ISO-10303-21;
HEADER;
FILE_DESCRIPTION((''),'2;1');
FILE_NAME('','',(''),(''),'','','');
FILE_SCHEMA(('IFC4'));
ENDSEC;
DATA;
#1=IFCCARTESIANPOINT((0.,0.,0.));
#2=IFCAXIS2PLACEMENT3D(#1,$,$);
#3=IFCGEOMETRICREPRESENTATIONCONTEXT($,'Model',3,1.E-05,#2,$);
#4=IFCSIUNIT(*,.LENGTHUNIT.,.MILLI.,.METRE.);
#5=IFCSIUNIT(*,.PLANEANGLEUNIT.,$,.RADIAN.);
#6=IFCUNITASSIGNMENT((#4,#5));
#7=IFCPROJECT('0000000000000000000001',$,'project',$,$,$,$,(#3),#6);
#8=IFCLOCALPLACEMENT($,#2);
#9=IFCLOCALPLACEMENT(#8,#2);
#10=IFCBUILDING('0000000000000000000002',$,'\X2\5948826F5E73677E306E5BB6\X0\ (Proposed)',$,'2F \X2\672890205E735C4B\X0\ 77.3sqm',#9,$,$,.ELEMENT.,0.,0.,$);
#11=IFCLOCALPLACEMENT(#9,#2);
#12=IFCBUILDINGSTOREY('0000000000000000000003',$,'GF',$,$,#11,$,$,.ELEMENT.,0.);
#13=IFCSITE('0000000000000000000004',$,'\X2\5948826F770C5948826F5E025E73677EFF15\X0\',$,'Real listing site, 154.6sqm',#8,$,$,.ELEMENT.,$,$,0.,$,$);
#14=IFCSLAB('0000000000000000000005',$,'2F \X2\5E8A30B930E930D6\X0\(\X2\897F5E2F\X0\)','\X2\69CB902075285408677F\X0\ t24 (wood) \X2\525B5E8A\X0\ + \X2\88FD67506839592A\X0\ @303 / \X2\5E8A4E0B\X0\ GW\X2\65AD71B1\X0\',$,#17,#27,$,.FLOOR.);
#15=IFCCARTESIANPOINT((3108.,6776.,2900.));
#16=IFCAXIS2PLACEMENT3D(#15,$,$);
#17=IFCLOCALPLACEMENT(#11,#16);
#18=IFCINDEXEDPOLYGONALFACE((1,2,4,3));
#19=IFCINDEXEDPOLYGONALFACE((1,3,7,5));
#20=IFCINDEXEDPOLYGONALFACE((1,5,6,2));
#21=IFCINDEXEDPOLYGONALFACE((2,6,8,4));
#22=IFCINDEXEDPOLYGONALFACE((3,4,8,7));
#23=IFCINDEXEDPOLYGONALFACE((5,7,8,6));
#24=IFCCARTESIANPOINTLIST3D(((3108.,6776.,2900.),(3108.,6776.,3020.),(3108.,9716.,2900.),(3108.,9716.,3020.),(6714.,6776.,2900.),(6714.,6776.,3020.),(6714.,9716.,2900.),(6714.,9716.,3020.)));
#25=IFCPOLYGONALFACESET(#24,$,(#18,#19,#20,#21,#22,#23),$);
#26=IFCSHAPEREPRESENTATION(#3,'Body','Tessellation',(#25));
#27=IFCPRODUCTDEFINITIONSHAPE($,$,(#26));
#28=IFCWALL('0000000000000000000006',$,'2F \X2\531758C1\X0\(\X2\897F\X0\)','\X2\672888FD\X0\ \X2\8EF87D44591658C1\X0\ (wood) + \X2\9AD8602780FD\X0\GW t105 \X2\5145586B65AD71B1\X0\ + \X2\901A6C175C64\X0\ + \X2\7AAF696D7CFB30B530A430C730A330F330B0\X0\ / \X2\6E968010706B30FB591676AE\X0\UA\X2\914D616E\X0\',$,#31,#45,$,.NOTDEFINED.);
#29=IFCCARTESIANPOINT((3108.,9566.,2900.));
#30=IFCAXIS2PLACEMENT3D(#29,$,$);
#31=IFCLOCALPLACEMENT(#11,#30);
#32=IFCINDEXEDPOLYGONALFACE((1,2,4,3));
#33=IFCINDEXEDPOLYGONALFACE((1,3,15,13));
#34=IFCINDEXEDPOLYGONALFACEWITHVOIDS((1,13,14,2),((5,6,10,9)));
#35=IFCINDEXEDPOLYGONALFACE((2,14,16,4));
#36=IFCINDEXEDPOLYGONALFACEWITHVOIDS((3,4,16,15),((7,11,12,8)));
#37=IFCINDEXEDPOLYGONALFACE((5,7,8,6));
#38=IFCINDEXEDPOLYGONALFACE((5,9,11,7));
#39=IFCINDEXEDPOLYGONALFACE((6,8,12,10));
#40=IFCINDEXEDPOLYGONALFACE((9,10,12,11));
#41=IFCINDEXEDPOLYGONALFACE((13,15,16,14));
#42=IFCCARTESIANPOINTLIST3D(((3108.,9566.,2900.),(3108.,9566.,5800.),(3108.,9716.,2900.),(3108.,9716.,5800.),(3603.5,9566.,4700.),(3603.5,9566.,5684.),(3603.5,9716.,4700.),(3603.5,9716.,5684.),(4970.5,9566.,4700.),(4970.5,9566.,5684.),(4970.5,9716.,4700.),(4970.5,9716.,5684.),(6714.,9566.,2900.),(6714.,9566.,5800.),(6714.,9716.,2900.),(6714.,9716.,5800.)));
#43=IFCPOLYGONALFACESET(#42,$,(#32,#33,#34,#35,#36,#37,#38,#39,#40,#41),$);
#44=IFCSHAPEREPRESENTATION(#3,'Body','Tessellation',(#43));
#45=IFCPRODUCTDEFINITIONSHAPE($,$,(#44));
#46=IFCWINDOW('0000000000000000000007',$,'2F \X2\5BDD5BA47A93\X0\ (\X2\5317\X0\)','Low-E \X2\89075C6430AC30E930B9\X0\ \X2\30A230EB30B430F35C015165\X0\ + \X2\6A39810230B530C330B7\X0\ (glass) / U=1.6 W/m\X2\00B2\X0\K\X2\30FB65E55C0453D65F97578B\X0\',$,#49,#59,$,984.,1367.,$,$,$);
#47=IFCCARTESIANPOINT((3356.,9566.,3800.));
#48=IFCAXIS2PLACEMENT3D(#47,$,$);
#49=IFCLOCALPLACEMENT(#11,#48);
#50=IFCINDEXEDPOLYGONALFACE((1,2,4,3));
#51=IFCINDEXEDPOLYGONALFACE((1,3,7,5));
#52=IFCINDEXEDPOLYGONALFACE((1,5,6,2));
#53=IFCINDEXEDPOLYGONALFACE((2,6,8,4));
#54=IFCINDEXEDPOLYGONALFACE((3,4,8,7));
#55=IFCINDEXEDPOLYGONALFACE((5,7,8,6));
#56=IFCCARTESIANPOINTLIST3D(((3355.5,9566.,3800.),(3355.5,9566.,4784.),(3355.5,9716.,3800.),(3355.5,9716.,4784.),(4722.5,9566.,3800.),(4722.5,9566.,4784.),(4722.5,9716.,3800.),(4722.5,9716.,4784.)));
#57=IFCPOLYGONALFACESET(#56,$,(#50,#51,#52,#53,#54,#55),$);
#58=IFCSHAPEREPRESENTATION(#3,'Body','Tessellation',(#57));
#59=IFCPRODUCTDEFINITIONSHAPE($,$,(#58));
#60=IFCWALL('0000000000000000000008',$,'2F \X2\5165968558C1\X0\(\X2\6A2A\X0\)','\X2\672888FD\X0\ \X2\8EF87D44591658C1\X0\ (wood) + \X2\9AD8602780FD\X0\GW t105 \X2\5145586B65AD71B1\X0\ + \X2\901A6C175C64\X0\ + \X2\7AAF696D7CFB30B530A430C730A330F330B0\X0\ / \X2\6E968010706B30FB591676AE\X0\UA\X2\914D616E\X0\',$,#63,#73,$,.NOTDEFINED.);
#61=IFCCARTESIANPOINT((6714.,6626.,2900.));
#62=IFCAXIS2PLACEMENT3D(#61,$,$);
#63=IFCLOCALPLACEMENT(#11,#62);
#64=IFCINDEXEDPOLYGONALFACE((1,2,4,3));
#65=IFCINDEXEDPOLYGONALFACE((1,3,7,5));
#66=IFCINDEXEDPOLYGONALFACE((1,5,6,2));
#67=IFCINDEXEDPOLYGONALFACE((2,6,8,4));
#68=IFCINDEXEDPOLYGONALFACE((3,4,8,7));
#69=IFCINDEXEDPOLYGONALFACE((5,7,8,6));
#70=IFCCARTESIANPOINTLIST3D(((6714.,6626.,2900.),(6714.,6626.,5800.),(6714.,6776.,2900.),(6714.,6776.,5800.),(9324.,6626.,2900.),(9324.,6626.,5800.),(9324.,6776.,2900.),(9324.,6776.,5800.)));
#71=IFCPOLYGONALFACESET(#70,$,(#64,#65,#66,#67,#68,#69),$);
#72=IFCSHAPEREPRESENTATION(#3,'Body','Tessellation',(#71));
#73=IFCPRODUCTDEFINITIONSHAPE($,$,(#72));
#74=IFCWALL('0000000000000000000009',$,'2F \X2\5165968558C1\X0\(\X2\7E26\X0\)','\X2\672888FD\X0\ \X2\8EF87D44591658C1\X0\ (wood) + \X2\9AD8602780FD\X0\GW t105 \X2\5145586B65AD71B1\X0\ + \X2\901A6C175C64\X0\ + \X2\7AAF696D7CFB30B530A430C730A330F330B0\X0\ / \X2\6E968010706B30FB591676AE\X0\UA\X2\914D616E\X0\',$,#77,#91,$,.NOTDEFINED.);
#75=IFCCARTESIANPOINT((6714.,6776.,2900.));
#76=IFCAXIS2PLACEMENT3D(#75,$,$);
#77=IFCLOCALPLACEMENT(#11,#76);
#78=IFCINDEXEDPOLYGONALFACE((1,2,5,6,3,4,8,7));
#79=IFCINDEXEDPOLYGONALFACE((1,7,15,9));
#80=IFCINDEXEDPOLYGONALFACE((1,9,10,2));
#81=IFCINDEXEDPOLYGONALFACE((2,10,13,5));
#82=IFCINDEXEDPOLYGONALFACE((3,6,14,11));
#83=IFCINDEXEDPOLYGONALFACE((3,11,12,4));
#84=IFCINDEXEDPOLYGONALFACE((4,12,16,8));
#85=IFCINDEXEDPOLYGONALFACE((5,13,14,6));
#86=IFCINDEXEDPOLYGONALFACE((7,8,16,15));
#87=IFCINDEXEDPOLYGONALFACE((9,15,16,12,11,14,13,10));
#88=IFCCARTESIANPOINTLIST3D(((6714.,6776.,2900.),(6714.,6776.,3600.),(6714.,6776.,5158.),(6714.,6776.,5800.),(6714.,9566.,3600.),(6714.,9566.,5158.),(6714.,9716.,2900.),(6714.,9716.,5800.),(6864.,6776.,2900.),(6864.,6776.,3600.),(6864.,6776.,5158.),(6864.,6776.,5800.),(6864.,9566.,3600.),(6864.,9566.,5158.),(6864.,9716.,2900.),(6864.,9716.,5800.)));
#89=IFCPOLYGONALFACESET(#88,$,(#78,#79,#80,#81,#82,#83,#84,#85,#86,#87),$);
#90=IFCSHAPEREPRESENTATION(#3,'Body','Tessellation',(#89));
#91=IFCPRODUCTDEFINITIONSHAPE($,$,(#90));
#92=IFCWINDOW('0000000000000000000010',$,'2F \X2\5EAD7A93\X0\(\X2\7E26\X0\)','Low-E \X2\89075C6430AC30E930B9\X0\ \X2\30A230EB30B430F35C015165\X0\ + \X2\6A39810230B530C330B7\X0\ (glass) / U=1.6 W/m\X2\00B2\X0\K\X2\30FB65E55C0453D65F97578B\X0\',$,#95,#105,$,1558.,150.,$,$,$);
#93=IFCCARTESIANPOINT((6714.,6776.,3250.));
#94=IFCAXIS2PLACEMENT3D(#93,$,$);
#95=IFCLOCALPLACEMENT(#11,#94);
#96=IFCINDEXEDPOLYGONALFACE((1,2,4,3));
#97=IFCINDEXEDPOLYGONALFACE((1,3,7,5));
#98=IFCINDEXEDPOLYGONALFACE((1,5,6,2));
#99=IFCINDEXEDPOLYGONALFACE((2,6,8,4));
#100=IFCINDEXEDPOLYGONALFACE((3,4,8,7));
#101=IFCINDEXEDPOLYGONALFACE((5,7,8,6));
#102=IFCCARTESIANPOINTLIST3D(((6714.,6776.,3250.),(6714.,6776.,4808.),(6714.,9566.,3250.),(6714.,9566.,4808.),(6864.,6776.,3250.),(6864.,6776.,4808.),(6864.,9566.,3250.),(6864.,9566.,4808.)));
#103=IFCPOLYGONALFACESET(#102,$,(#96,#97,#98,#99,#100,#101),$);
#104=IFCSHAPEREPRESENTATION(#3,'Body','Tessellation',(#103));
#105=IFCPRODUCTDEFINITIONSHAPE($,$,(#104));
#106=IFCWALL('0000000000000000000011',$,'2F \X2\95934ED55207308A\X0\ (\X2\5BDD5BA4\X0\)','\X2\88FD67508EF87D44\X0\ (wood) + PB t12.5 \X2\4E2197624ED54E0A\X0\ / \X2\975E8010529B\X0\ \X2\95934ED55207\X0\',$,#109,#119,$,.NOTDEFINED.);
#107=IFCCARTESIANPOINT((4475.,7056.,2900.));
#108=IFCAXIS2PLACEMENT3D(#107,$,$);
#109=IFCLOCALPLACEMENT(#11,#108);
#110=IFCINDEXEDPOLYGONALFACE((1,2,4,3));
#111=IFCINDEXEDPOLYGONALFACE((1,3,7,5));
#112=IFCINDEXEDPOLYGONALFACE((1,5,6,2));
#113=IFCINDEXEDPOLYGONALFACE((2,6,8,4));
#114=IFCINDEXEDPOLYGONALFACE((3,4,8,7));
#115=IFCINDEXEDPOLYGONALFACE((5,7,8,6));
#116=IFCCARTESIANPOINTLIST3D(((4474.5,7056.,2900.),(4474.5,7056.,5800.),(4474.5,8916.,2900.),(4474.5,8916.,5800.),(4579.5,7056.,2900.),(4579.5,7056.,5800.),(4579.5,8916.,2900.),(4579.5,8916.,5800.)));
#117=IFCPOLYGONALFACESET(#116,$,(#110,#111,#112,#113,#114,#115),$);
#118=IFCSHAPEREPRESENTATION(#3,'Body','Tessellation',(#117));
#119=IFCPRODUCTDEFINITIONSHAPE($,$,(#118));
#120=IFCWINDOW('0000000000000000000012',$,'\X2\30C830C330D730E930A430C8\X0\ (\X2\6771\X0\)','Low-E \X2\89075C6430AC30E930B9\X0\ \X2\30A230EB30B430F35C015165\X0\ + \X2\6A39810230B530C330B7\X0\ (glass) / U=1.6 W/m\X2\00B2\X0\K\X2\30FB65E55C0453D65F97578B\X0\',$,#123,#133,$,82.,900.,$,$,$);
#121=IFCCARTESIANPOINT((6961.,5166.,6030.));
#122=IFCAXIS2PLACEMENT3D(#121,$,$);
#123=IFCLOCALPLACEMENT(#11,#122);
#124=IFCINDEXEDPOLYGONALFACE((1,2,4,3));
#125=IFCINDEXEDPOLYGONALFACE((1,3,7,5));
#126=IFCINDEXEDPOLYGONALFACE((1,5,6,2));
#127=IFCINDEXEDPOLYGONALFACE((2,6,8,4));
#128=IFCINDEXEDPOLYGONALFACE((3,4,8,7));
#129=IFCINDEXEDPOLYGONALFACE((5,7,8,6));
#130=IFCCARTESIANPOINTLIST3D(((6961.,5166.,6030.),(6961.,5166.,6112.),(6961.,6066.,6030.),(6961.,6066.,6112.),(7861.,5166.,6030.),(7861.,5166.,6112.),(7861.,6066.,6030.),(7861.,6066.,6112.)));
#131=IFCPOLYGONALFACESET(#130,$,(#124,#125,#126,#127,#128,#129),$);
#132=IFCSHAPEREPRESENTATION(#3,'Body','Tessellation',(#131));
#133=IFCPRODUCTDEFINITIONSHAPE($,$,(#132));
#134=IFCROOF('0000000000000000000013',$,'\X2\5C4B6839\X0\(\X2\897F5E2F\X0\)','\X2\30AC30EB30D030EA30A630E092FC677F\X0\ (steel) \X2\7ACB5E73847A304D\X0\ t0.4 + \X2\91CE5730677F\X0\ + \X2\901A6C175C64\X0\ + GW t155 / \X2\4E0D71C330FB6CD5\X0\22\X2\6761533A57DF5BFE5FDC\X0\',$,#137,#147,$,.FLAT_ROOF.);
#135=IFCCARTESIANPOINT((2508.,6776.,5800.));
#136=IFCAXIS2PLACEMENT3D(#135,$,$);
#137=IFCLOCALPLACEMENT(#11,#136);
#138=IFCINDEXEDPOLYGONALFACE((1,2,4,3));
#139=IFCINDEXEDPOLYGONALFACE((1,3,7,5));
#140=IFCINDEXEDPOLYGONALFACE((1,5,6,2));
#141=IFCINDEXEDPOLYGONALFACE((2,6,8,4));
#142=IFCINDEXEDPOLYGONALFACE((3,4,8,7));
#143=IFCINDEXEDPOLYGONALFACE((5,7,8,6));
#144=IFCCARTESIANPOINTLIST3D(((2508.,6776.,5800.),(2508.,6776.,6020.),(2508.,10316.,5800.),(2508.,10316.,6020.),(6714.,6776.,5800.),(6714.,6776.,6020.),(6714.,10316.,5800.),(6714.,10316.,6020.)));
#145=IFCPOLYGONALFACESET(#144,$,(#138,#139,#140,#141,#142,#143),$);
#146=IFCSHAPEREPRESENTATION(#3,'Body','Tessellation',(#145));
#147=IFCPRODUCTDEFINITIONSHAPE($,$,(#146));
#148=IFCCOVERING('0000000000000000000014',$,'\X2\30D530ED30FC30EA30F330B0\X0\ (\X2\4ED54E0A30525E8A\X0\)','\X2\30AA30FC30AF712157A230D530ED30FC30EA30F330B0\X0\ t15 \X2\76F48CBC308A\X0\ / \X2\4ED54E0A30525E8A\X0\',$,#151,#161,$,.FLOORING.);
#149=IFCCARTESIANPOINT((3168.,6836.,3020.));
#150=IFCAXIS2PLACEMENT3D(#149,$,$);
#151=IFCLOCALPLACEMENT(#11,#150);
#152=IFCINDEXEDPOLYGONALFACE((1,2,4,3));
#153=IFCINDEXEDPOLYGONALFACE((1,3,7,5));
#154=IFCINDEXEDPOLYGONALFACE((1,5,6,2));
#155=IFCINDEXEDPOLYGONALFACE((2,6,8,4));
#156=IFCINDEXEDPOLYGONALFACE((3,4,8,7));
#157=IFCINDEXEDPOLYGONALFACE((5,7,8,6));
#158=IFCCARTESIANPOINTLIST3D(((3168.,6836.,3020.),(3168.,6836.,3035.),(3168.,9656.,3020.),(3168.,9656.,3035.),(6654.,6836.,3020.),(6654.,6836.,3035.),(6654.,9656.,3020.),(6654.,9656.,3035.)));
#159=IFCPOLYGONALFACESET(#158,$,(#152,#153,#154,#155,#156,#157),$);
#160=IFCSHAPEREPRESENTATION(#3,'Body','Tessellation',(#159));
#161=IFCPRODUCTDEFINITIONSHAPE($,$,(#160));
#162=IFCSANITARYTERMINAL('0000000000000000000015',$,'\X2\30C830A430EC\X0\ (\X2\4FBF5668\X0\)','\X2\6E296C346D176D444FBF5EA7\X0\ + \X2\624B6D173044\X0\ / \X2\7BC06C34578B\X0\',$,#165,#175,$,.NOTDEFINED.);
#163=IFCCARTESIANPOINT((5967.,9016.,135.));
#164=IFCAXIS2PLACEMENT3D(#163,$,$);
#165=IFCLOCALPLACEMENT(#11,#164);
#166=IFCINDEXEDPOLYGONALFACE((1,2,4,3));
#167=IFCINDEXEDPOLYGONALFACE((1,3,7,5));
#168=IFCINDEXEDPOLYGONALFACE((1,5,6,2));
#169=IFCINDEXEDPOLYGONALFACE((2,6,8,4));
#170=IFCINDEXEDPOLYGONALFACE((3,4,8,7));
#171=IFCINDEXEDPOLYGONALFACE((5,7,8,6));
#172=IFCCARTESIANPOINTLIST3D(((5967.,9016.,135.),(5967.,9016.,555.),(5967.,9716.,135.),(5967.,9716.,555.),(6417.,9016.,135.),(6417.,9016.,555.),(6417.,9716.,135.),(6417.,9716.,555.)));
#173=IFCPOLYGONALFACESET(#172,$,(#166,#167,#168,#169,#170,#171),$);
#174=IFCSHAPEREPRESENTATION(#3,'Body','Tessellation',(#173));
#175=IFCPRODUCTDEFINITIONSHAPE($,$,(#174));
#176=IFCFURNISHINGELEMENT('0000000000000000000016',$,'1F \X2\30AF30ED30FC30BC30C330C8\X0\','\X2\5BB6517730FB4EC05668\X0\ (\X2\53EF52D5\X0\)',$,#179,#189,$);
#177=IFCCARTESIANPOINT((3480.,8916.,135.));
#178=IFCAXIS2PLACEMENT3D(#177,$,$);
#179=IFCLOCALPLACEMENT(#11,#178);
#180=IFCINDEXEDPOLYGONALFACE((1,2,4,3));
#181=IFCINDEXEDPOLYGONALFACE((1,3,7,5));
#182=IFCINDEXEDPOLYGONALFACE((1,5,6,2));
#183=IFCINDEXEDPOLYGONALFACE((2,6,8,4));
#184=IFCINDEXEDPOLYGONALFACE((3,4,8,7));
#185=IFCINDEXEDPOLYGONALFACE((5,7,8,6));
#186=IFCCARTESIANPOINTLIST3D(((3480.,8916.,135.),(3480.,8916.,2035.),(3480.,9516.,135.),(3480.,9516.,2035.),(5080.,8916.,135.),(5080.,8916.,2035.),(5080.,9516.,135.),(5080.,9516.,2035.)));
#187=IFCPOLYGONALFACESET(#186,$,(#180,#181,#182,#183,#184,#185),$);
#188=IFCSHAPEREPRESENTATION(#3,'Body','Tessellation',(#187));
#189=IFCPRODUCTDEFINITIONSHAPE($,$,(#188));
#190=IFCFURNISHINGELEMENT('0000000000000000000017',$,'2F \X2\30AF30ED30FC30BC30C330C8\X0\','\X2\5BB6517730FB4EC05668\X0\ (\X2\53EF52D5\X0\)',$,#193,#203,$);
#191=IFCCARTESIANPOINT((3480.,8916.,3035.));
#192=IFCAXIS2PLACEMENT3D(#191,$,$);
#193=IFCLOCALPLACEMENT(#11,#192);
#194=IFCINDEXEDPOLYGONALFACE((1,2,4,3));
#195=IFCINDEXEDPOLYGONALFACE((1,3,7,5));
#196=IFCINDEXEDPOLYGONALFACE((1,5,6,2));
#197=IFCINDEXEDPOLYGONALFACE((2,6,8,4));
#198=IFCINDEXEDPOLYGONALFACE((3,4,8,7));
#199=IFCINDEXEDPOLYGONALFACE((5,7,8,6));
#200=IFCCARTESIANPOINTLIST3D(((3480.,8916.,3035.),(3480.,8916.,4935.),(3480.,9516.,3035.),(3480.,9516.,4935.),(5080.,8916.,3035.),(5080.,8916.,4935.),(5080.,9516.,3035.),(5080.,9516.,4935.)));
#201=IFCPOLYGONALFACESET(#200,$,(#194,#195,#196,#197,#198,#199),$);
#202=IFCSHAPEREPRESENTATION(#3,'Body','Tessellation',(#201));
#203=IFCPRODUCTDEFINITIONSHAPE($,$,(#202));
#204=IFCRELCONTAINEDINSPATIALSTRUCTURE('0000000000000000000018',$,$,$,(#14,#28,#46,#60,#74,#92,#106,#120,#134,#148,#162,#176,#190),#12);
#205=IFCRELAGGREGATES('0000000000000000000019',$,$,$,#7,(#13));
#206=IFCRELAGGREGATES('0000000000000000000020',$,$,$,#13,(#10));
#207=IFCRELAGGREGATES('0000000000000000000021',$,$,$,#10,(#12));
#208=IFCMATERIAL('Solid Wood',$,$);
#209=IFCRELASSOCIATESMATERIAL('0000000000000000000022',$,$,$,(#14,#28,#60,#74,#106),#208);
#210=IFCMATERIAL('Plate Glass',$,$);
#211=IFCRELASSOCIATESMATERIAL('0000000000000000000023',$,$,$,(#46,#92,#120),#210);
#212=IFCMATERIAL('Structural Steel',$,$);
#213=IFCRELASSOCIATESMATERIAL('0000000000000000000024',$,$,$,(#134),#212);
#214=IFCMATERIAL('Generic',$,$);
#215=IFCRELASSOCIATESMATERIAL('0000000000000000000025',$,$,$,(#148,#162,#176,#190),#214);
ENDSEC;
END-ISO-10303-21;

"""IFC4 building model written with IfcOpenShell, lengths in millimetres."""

from ifc_helpers import new_model, si_unit, frame, frame_2d, origin, place, context, project, spatial, rectangle, extrude, material, element, fill, save


model = new_model("IFC4")

# Units and contexts
model_context = context("Model", 3, precision=1e-05, world=origin())
ifc_project = project(units=[si_unit("LENGTHUNIT", "METRE", prefix="MILLI"), si_unit("PLANEANGLEUNIT", "RADIAN")], contexts=[model_context])

# Site, building, storey
site_placement = place(None, origin())
site = spatial("IfcSite", under=ifc_project, at=site_placement, Name="奈良県奈良市平松５", ObjectType="Real listing site, 154.6sqm", CompositionType="ELEMENT", RefElevation=0.0)
building_placement = place(site_placement, origin())
building = spatial("IfcBuilding", under=site, at=building_placement, Name="奈良平松の家 (Proposed)", ObjectType="2F 木造平屋 77.3sqm", CompositionType="ELEMENT", ElevationOfRefHeight=0.0, ElevationOfTerrain=0.0)
storey_placement = place(building_placement, origin())
storey = spatial("IfcBuildingStorey", under=building, at=storey_placement, Name="GF", CompositionType="ELEMENT", Elevation=0.0)

# Slab
ifc_material_1 = material(Name="Solid Wood")
slab_placement = place(storey_placement, frame((3108.0, 6776.0, 2900.0)))
element("IfcSlab", 1, at=slab_placement, inside=storey, material=ifc_material_1, Name="2F 床スラブ(西帯)", Description="構造用合板 t24 (wood) 剛床 + 製材根太 @303 / 床下 GW断熱", PredefinedType="FLOOR", context=model_context, shape_type="SweptSolid", body=[
    extrude(rectangle(XDim=3606.0, YDim=2940.0, at=frame_2d((1803.0, 1470.0))), frame((3108.0, 6776.0, 2900.0)), (0.0, 0.0, 1.0), 120.0),
])

# Wall, opening, window
wall_1_placement = place(storey_placement, frame((3108.0, 9566.0, 2900.0)))
wall_1 = element("IfcWall", 2, at=wall_1_placement, inside=storey, material=ifc_material_1, Name="2F 北壁(西)", Description="木製 軸組外壁 (wood) + 高性能GW t105 充填断熱 + 通気層 + 窯業系サイディング / 準耐火・外皮UA配慮", PredefinedType="NOTDEFINED", context=model_context, shape_type="SweptSolid", body=[
    extrude(rectangle(XDim=3606.0, YDim=150.0, at=frame_2d((1803.0, 75.0))), frame((3108.0, 9566.0, 2900.0)), (0.0, 0.0, 1.0), 2900.0),
])
opening_1_placement = place(storey_placement, frame((3356.0, 9566.0, 3800.0)))
opening_1 = element("IfcOpeningElement", 3, at=opening_1_placement, cuts=wall_1, PredefinedType="NOTDEFINED", context=model_context, shape_type="SweptSolid", body=[
    extrude(rectangle(XDim=1367.0, YDim=150.0, at=frame_2d((683.0, 75.0))), frame((3356.0, 9566.0, 3800.0)), (0.0, 0.0, 1.0), 984.0),
])
ifc_material_2 = material(Name="Plate Glass")
window_1_placement = place(storey_placement, frame((3356.0, 9566.0, 3800.0)))
window_1 = element("IfcWindow", 4, at=window_1_placement, inside=storey, material=ifc_material_2, Name="2F 寝室窓 (北)", Description="Low-E 複層ガラス アルゴン封入 + 樹脂サッシ (glass) / U=1.6 W/m²K・日射取得型", OverallHeight=984.0, OverallWidth=1367.0, context=model_context, shape_type="SweptSolid", body=[
    extrude(rectangle(XDim=1367.0, YDim=150.0, at=frame_2d((683.0, 75.0))), frame((3356.0, 9566.0, 3800.0)), (0.0, 0.0, 1.0), 984.0),
])
fill(opening_1, window_1)

# Wall
wall_2_placement = place(storey_placement, frame((6714.0, 6626.0, 2900.0)))
element("IfcWall", 5, at=wall_2_placement, inside=storey, material=ifc_material_1, Name="2F 入隅壁(横)", Description="木製 軸組外壁 (wood) + 高性能GW t105 充填断熱 + 通気層 + 窯業系サイディング / 準耐火・外皮UA配慮", PredefinedType="NOTDEFINED", context=model_context, shape_type="SweptSolid", body=[
    extrude(rectangle(XDim=2610.0, YDim=150.0, at=frame_2d((1305.0, 75.0))), frame((6714.0, 6626.0, 2900.0)), (0.0, 0.0, 1.0), 2900.0),
])

# Wall, opening, window
wall_3_placement = place(storey_placement, frame((6714.0, 6776.0, 2900.0)))
wall_3 = element("IfcWall", 6, at=wall_3_placement, inside=storey, material=ifc_material_1, Name="2F 入隅壁(縦)", Description="木製 軸組外壁 (wood) + 高性能GW t105 充填断熱 + 通気層 + 窯業系サイディング / 準耐火・外皮UA配慮", PredefinedType="NOTDEFINED", context=model_context, shape_type="SweptSolid", body=[
    extrude(rectangle(XDim=150.0, YDim=2940.0, at=frame_2d((75.0, 1470.0))), frame((6714.0, 6776.0, 2900.0)), (0.0, 0.0, 1.0), 2900.0),
])
opening_2_placement = place(storey_placement, frame((6714.0, 6776.0, 3250.0)))
opening_2 = element("IfcOpeningElement", 7, at=opening_2_placement, cuts=wall_3, PredefinedType="NOTDEFINED", context=model_context, shape_type="SweptSolid", body=[
    extrude(rectangle(XDim=150.0, YDim=2790.0, at=frame_2d((75.0, 1395.0))), frame((6714.0, 6776.0, 3250.0)), (0.0, 0.0, 1.0), 1558.0),
])
window_2_placement = place(storey_placement, frame((6714.0, 6776.0, 3250.0)))
window_2 = element("IfcWindow", 8, at=window_2_placement, inside=storey, material=ifc_material_2, Name="2F 庭窓(縦)", Description="Low-E 複層ガラス アルゴン封入 + 樹脂サッシ (glass) / U=1.6 W/m²K・日射取得型", OverallHeight=1558.0, OverallWidth=150.0, context=model_context, shape_type="SweptSolid", body=[
    extrude(rectangle(XDim=150.0, YDim=2790.0, at=frame_2d((75.0, 1395.0))), frame((6714.0, 6776.0, 3250.0)), (0.0, 0.0, 1.0), 1558.0),
])
fill(opening_2, window_2)

# Wall
wall_4_placement = place(storey_placement, frame((4475.0, 7056.0, 2900.0)))
element("IfcWall", 9, at=wall_4_placement, inside=storey, material=ifc_material_1, Name="2F 間仕切り (寝室)", Description="製材軸組 (wood) + PB t12.5 両面仕上 / 非耐力 間仕切", PredefinedType="NOTDEFINED", context=model_context, shape_type="SweptSolid", body=[
    extrude(rectangle(XDim=105.0, YDim=1860.0, at=frame_2d((52.0, 930.0))), frame((4475.0, 7056.0, 2900.0)), (0.0, 0.0, 1.0), 2900.0),
])

# Window
window_3_placement = place(storey_placement, frame((6961.0, 5166.0, 6030.0)))
element("IfcWindow", 10, at=window_3_placement, inside=storey, material=ifc_material_2, Name="トップライト (東)", Description="Low-E 複層ガラス アルゴン封入 + 樹脂サッシ (glass) / U=1.6 W/m²K・日射取得型", OverallHeight=82.0, OverallWidth=900.0, context=model_context, shape_type="SweptSolid", body=[
    extrude(rectangle(XDim=900.0, YDim=900.0, at=frame_2d((450.0, 450.0))), frame((6961.0, 5166.0, 6030.0)), (0.0, 0.0, 1.0), 82.0),
])

# Roof
ifc_material_3 = material(Name="Structural Steel")
for number, where, name in (
    (11, (2508.0, 6776.0, 5800.0), "屋根(西帯)"),
):
    element("IfcRoof", number, at=place(storey_placement, frame(where)), inside=storey, material=ifc_material_3, Name=name, Description="ガルバリウム鋼板 (steel) 立平葺き t0.4 + 野地板 + 通気層 + GW t155 / 不燃・法22条区域対応", PredefinedType="FLAT_ROOF", context=model_context, shape_type="SweptSolid", body=[
        extrude(rectangle(XDim=4206.0, YDim=3540.0, at=frame_2d((2103.0, 1770.0))), frame((2508.0, 6776.0, 5800.0)), (0.0, 0.0, 1.0), 220.0),
    ])

# Covering
ifc_material_4 = material(Name="Generic")
covering_placement = place(storey_placement, frame((3168.0, 6836.0, 3020.0)))
element("IfcCovering", 12, at=covering_placement, inside=storey, material=ifc_material_4, Name="フローリング (仕上げ床)", Description="オーク無垢フローリング t15 直貼り / 仕上げ床", PredefinedType="FLOORING", context=model_context, shape_type="SweptSolid", body=[
    extrude(rectangle(XDim=3486.0, YDim=2820.0, at=frame_2d((1743.0, 1410.0))), frame((3168.0, 6836.0, 3020.0)), (0.0, 0.0, 1.0), 15.0),
])

# Sanitary terminal
sanitary_terminal_placement = place(storey_placement, frame((5967.0, 9016.0, 135.0)))
element("IfcSanitaryTerminal", 13, at=sanitary_terminal_placement, inside=storey, material=ifc_material_4, Name="トイレ (便器)", Description="温水洗浄便座 + 手洗い / 節水型", PredefinedType="NOTDEFINED", context=model_context, shape_type="SweptSolid", body=[
    extrude(rectangle(XDim=450.0, YDim=700.0, at=frame_2d((225.0, 350.0))), frame((5967.0, 9016.0, 135.0)), (0.0, 0.0, 1.0), 420.0),
])

# Furnishing elements
furnishing_1_placement = place(storey_placement, frame((3480.0, 8916.0, 135.0)))
element("IfcFurnishingElement", 14, at=furnishing_1_placement, inside=storey, material=ifc_material_4, Name="1F クローゼット", Description="家具・什器 (可動)", context=model_context, shape_type="SweptSolid", body=[
    extrude(rectangle(XDim=1600.0, YDim=600.0, at=frame_2d((800.0, 300.0))), frame((3480.0, 8916.0, 135.0)), (0.0, 0.0, 1.0), 1900.0),
])
furnishing_2_placement = place(storey_placement, frame((3480.0, 8916.0, 3035.0)))
element("IfcFurnishingElement", 15, at=furnishing_2_placement, inside=storey, material=ifc_material_4, Name="2F クローゼット", Description="家具・什器 (可動)", context=model_context, shape_type="SweptSolid", body=[
    extrude(rectangle(XDim=1600.0, YDim=600.0, at=frame_2d((800.0, 300.0))), frame((3480.0, 8916.0, 3035.0)), (0.0, 0.0, 1.0), 1900.0),
])

save(model, "model.ifc")
